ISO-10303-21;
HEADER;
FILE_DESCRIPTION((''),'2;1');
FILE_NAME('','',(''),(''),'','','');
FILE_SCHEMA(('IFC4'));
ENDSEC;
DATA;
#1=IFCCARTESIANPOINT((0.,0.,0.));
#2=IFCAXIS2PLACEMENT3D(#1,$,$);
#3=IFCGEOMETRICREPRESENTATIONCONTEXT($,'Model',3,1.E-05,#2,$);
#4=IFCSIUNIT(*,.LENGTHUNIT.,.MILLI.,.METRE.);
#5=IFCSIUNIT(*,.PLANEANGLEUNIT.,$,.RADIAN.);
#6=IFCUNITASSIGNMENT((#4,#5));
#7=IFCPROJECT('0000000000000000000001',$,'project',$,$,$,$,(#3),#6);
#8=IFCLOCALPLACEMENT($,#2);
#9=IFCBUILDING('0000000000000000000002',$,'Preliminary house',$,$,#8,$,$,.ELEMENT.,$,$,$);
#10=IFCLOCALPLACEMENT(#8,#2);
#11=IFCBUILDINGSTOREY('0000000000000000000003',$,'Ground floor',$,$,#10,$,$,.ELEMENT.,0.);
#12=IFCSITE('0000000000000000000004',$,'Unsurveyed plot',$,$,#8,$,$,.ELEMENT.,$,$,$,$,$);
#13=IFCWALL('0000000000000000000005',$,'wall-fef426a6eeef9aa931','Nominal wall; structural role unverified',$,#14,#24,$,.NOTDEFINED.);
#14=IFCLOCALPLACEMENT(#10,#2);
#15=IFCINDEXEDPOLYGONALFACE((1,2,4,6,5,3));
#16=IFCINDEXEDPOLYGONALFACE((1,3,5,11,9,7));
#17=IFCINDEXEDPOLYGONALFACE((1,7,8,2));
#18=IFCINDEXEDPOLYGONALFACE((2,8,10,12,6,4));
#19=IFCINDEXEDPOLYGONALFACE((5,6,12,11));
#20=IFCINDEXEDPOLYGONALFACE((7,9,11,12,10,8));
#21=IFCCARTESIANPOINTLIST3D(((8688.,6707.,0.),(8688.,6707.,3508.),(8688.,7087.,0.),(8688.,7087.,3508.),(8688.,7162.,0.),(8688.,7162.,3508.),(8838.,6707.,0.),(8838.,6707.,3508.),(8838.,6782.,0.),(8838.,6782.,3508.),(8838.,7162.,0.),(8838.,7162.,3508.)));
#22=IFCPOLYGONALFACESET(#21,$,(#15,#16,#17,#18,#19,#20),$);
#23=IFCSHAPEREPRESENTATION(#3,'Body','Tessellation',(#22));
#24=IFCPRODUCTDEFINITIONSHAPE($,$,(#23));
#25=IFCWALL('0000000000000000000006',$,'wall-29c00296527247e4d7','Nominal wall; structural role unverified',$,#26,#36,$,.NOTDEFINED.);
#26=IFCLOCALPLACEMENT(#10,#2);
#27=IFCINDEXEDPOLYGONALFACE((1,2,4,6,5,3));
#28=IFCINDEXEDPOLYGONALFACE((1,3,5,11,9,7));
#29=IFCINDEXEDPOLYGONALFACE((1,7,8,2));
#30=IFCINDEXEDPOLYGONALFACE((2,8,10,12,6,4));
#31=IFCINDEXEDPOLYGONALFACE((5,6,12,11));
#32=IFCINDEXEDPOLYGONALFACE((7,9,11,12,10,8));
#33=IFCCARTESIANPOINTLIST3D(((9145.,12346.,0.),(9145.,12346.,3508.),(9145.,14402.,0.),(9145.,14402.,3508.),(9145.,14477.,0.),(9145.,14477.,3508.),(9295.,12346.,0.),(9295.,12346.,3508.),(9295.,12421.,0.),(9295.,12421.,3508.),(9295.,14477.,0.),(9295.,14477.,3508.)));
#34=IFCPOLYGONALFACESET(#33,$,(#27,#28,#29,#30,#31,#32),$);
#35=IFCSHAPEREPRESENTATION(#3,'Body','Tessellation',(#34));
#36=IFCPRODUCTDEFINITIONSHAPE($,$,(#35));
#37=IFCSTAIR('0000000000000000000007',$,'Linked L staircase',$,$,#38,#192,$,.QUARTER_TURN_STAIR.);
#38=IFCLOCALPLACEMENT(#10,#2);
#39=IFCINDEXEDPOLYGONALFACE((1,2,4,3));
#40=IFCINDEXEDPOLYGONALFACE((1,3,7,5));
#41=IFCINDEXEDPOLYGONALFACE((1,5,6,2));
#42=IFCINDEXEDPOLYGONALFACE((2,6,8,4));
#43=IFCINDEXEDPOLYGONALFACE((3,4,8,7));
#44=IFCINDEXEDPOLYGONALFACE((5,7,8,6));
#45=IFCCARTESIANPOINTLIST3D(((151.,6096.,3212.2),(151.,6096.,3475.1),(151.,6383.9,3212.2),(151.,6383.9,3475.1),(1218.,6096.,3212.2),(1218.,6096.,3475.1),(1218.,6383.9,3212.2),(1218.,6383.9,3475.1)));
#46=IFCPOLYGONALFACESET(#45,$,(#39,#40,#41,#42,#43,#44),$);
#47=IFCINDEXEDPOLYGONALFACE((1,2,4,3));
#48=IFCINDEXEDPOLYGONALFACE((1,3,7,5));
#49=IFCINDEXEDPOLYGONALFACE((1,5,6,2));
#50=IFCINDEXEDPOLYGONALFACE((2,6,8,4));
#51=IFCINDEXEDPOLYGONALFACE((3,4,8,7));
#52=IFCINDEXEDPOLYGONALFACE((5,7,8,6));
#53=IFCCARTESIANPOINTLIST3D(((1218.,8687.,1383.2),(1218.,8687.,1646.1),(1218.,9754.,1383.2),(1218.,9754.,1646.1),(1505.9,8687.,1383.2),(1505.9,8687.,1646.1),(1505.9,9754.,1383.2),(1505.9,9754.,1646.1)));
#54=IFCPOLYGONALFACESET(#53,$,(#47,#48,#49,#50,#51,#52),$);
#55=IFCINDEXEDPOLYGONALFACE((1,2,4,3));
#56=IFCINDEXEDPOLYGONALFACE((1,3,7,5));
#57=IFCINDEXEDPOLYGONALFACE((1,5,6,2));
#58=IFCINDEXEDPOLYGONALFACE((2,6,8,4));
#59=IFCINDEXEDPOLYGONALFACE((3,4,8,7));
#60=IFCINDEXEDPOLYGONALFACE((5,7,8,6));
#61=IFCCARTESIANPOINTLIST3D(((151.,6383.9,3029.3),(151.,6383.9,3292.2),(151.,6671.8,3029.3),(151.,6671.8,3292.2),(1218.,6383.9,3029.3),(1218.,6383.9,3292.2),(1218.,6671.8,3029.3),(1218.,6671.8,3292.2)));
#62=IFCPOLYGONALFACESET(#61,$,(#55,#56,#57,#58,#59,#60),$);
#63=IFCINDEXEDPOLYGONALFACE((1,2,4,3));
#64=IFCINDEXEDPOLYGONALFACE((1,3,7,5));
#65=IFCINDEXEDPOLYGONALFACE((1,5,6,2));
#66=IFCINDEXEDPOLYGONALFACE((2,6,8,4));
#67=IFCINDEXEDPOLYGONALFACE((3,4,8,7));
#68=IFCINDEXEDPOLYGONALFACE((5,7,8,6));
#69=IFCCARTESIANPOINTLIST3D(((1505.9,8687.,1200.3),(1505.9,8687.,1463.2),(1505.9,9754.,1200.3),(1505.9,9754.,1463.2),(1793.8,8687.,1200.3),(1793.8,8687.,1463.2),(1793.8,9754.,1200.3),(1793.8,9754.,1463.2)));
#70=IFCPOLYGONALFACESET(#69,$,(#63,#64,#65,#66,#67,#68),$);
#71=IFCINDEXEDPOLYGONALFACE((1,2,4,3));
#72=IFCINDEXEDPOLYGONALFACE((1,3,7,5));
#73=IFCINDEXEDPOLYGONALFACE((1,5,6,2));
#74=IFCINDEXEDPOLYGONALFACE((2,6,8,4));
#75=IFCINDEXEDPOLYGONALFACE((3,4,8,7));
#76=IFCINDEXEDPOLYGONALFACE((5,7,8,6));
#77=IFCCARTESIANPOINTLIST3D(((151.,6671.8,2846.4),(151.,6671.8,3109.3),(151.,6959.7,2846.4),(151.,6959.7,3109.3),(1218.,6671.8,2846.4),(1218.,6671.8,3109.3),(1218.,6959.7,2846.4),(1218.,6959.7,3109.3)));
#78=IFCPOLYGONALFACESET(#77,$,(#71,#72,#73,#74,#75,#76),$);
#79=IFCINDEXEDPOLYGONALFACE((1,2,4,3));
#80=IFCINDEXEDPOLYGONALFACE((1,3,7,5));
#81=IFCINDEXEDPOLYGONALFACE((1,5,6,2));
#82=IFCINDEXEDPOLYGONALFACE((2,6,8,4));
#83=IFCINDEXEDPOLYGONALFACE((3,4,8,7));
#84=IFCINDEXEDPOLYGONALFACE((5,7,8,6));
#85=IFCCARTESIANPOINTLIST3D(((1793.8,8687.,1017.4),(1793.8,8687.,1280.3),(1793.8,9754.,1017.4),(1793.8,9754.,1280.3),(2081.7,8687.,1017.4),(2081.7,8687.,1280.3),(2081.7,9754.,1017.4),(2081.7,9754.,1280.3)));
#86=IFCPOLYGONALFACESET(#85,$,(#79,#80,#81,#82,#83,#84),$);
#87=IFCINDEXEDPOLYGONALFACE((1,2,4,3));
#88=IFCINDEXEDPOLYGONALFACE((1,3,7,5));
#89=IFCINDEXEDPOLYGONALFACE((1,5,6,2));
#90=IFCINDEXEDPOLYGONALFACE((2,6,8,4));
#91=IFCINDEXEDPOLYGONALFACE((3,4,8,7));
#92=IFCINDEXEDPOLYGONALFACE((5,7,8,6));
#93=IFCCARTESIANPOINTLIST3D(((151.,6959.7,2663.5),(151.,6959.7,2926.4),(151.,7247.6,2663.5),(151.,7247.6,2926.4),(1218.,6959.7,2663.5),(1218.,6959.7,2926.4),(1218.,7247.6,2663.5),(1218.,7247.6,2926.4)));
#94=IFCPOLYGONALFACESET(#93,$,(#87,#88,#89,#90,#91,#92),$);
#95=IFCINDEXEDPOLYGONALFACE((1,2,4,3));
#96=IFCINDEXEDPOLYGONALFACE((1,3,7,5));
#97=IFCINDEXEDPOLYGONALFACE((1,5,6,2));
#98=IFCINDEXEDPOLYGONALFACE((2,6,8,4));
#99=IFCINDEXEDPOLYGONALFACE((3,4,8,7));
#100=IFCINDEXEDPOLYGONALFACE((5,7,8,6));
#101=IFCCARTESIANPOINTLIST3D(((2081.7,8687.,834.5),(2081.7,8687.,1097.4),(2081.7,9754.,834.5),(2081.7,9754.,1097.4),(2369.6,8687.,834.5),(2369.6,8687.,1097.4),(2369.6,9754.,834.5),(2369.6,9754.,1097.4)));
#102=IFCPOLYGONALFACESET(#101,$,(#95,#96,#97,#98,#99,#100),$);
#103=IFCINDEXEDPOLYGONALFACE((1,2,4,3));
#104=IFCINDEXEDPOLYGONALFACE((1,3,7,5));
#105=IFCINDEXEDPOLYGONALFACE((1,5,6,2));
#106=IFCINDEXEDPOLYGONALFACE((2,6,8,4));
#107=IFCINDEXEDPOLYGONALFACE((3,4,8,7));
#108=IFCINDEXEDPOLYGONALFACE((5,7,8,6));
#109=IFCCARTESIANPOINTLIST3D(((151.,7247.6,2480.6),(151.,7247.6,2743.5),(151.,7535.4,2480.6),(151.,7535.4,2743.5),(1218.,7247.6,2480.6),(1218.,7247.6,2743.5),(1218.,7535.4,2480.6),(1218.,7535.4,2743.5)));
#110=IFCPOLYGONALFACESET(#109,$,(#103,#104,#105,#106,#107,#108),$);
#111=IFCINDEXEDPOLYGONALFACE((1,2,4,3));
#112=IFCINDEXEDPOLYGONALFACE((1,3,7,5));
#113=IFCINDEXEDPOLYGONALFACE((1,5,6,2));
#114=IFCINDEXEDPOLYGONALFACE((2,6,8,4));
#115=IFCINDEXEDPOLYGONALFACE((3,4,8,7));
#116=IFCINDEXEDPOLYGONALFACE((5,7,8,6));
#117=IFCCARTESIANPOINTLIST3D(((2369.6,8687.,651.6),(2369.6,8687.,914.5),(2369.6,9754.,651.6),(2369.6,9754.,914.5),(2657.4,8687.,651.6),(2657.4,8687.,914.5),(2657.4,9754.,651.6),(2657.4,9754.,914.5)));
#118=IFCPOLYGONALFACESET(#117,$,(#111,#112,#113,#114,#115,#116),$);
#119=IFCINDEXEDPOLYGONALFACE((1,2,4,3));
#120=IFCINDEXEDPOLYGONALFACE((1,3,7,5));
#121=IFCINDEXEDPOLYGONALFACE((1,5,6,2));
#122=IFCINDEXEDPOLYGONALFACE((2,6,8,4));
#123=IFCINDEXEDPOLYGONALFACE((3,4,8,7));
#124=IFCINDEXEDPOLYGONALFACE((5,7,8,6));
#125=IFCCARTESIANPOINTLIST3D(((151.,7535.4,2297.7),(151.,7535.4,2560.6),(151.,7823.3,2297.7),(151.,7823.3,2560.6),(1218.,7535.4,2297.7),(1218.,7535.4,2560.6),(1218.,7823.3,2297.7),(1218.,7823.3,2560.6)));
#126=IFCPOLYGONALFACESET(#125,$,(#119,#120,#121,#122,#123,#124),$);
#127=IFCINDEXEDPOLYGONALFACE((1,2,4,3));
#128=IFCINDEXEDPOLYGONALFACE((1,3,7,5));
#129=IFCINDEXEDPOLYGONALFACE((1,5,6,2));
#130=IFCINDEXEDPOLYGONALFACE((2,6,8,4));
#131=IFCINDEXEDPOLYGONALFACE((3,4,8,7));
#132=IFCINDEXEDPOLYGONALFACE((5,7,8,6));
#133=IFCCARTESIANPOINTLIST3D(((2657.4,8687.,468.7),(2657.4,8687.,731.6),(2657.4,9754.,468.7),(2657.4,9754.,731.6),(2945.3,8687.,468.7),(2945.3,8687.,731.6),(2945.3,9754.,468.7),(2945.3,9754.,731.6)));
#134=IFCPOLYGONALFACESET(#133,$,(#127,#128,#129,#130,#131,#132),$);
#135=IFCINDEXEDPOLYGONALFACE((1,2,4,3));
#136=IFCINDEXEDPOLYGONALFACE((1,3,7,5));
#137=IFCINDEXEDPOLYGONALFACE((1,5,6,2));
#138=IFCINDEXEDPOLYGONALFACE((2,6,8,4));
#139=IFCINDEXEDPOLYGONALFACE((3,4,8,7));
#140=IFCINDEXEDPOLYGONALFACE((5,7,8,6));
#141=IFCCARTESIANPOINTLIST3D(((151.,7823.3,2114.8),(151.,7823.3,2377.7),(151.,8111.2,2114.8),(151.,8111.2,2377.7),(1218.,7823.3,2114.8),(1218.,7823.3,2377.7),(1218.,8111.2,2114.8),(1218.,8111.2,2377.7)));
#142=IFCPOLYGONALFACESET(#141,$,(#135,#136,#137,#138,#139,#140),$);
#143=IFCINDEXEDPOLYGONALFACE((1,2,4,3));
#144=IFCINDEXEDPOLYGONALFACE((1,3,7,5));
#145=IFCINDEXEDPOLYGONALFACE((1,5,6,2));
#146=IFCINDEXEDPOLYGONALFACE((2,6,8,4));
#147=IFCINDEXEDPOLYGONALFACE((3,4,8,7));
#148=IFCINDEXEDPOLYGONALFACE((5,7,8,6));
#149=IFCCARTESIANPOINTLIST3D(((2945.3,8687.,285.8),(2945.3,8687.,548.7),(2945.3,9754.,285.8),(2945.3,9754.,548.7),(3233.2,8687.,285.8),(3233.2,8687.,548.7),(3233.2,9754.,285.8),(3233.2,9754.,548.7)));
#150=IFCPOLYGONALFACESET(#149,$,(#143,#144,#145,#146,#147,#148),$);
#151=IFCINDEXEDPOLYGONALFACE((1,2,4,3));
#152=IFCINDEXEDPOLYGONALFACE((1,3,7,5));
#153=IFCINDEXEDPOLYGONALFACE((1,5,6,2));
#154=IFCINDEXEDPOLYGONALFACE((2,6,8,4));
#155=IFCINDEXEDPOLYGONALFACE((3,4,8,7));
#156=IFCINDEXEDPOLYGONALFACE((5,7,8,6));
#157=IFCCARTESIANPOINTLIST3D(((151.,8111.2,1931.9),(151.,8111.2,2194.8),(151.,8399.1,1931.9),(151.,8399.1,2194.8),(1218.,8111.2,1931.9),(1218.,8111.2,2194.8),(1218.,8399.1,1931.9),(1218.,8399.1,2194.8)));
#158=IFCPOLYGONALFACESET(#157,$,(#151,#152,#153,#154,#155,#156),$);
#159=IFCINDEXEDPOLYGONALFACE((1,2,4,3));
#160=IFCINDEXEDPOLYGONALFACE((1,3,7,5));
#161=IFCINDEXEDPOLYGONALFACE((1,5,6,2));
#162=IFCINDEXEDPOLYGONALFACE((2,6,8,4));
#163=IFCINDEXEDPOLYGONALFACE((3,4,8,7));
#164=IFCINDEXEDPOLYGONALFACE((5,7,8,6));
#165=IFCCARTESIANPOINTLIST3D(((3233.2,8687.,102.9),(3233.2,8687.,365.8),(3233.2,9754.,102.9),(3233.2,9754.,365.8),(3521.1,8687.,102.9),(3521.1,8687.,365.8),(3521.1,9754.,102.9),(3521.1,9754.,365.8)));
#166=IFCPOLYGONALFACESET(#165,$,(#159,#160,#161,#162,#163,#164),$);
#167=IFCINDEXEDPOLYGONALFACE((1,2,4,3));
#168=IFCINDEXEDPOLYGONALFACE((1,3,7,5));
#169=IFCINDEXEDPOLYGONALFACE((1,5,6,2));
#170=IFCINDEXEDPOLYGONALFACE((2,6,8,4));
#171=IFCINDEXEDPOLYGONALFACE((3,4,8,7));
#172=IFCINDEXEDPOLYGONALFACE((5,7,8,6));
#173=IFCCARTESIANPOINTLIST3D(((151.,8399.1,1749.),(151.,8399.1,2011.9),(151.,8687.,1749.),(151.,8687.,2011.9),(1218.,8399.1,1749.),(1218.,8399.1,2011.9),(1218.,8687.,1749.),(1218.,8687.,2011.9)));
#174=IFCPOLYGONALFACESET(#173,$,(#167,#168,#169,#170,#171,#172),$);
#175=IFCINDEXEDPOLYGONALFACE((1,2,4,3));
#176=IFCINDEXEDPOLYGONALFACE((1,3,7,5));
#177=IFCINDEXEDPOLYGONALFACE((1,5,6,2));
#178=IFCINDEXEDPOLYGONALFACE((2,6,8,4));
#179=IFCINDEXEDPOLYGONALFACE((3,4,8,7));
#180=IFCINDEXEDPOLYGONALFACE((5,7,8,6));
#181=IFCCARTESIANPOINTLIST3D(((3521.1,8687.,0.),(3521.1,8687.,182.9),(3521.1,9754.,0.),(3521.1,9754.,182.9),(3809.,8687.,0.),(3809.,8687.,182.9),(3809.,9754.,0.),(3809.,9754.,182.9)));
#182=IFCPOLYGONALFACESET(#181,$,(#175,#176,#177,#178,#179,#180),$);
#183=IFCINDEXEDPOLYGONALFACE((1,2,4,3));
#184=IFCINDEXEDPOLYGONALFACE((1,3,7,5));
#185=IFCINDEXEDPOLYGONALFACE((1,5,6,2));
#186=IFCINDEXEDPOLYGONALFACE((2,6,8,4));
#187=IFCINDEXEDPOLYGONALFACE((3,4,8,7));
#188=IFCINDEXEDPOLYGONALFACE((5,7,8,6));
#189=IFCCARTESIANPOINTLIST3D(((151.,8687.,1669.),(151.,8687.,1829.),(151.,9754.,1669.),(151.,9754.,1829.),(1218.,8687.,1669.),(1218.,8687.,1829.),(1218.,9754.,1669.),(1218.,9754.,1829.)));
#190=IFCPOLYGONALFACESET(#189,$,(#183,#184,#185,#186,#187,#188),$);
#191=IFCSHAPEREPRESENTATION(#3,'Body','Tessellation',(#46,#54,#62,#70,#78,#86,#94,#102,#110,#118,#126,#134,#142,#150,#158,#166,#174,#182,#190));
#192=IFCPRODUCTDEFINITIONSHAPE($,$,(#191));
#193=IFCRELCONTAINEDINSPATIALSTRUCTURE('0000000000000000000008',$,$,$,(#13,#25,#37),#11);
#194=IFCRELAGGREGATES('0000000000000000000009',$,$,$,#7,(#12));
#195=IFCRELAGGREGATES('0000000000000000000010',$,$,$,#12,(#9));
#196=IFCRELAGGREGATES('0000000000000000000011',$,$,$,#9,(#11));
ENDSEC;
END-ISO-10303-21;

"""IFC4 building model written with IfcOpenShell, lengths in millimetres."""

from ifc_helpers import new_model, si_unit, frame, origin, place, context, project, spatial, polyline, outline, extrude, element, save


model = new_model("IFC4")

# Units and contexts
model_context = context("Model", 3, precision=1e-05, world=origin())
ifc_project = project(units=[si_unit("LENGTHUNIT", "METRE", prefix="MILLI"), si_unit("PLANEANGLEUNIT", "RADIAN")], contexts=[model_context])

# Site, building, storey
placement_1 = place(None, origin())
site = spatial("IfcSite", under=ifc_project, at=placement_1, Name="Unsurveyed plot", CompositionType="ELEMENT")
building = spatial("IfcBuilding", under=site, at=placement_1, Name="Preliminary house", CompositionType="ELEMENT")
placement_2 = place(placement_1, origin())
storey = spatial("IfcBuildingStorey", under=building, at=placement_2, Name="Ground floor", CompositionType="ELEMENT", Elevation=0.0)

# Wall
element("IfcWall", 1, at=placement_2, inside=storey, Name="wall-fef426a6eeef9aa931", Description="Nominal wall; structural role unverified", PredefinedType="NOTDEFINED", context=model_context, shape_type="SweptSolid", body=[
    extrude(outline(polyline([(8688.0, 7087.0), (8688.0, 7162.0), (8838.0, 7162.0), (8838.0, 6782.0), (8838.0, 6707.0), (8688.0, 6707.0), (8688.0, 7087.0)])), origin(), (0.0, 0.0, 1.0), 3508.0),
])

# Wall
element("IfcWall", 2, at=placement_2, inside=storey, Name="wall-29c00296527247e4d7", Description="Nominal wall; structural role unverified", PredefinedType="NOTDEFINED", context=model_context, shape_type="SweptSolid", body=[
    extrude(outline(polyline([(9145.0, 14402.0), (9145.0, 14477.0), (9295.0, 14477.0), (9295.0, 12421.0), (9295.0, 12346.0), (9145.0, 12346.0), (9145.0, 14402.0)])), origin(), (0.0, 0.0, 1.0), 3508.0),
])

# Stair
element("IfcStair", 3, at=placement_2, inside=storey, Name="Linked L staircase", PredefinedType="QUARTER_TURN_STAIR", context=model_context, shape_type="SweptSolid", body=[
    extrude(outline(polyline([(1218.0, 6096.0), (1218.0, 6383.9), (151.0, 6383.9), (151.0, 6096.0), (1218.0, 6096.0)])), frame((0.0, 0.0, 3212.2)), (0.0, 0.0, 1.0), 262.9),
    extrude(outline(polyline([(1505.9, 8687.0), (1505.9, 9754.0), (1218.0, 9754.0), (1218.0, 8687.0), (1505.9, 8687.0)])), frame((0.0, 0.0, 1383.2)), (0.0, 0.0, 1.0), 262.9),
    extrude(outline(polyline([(1218.0, 6383.9), (1218.0, 6671.8), (151.0, 6671.8), (151.0, 6383.9), (1218.0, 6383.9)])), frame((0.0, 0.0, 3029.3)), (0.0, 0.0, 1.0), 262.9),
    extrude(outline(polyline([(1793.8, 8687.0), (1793.8, 9754.0), (1505.9, 9754.0), (1505.9, 8687.0), (1793.8, 8687.0)])), frame((0.0, 0.0, 1200.3)), (0.0, 0.0, 1.0), 262.9),
    extrude(outline(polyline([(1218.0, 6671.8), (1218.0, 6959.7), (151.0, 6959.7), (151.0, 6671.8), (1218.0, 6671.8)])), frame((0.0, 0.0, 2846.4)), (0.0, 0.0, 1.0), 262.9),
    extrude(outline(polyline([(2081.7, 8687.0), (2081.7, 9754.0), (1793.8, 9754.0), (1793.8, 8687.0), (2081.7, 8687.0)])), frame((0.0, 0.0, 1017.4)), (0.0, 0.0, 1.0), 262.9),
    extrude(outline(polyline([(1218.0, 6959.7), (1218.0, 7247.6), (151.0, 7247.6), (151.0, 6959.7), (1218.0, 6959.7)])), frame((0.0, 0.0, 2663.5)), (0.0, 0.0, 1.0), 262.9),
    extrude(outline(polyline([(2369.6, 8687.0), (2369.6, 9754.0), (2081.7, 9754.0), (2081.7, 8687.0), (2369.6, 8687.0)])), frame((0.0, 0.0, 834.5)), (0.0, 0.0, 1.0), 262.9),
    extrude(outline(polyline([(1218.0, 7247.6), (1218.0, 7535.4), (151.0, 7535.4), (151.0, 7247.6), (1218.0, 7247.6)])), frame((0.0, 0.0, 2480.6)), (0.0, 0.0, 1.0), 262.9),
    extrude(outline(polyline([(2657.4, 8687.0), (2657.4, 9754.0), (2369.6, 9754.0), (2369.6, 8687.0), (2657.4, 8687.0)])), frame((0.0, 0.0, 651.6)), (0.0, 0.0, 1.0), 262.9),
    extrude(outline(polyline([(1218.0, 7535.4), (1218.0, 7823.3), (151.0, 7823.3), (151.0, 7535.4), (1218.0, 7535.4)])), frame((0.0, 0.0, 2297.7)), (0.0, 0.0, 1.0), 262.9),
    extrude(outline(polyline([(2945.3, 8687.0), (2945.3, 9754.0), (2657.4, 9754.0), (2657.4, 8687.0), (2945.3, 8687.0)])), frame((0.0, 0.0, 468.7)), (0.0, 0.0, 1.0), 262.9),
    extrude(outline(polyline([(1218.0, 7823.3), (1218.0, 8111.2), (151.0, 8111.2), (151.0, 7823.3), (1218.0, 7823.3)])), frame((0.0, 0.0, 2114.8)), (0.0, 0.0, 1.0), 262.9),
    extrude(outline(polyline([(3233.2, 8687.0), (3233.2, 9754.0), (2945.3, 9754.0), (2945.3, 8687.0), (3233.2, 8687.0)])), frame((0.0, 0.0, 285.8)), (0.0, 0.0, 1.0), 262.9),
    extrude(outline(polyline([(1218.0, 8111.2), (1218.0, 8399.1), (151.0, 8399.1), (151.0, 8111.2), (1218.0, 8111.2)])), frame((0.0, 0.0, 1931.9)), (0.0, 0.0, 1.0), 262.9),
    extrude(outline(polyline([(3521.1, 8687.0), (3521.1, 9754.0), (3233.2, 9754.0), (3233.2, 8687.0), (3521.1, 8687.0)])), frame((0.0, 0.0, 102.9)), (0.0, 0.0, 1.0), 262.9),
    extrude(outline(polyline([(1218.0, 8399.1), (1218.0, 8687.0), (151.0, 8687.0), (151.0, 8399.1), (1218.0, 8399.1)])), frame((0.0, 0.0, 1749.0)), (0.0, 0.0, 1.0), 262.9),
    extrude(outline(polyline([(3809.0, 8687.0), (3809.0, 9754.0), (3521.1, 9754.0), (3521.1, 8687.0), (3809.0, 8687.0)])), origin(), (0.0, 0.0, 1.0), 182.9),
    extrude(outline(polyline([(1218.0, 8687.0), (1218.0, 9754.0), (151.0, 9754.0), (151.0, 8687.0), (1218.0, 8687.0)])), frame((0.0, 0.0, 1669.0)), (0.0, 0.0, 1.0), 160.0),
])

save(model, "model.ifc")
